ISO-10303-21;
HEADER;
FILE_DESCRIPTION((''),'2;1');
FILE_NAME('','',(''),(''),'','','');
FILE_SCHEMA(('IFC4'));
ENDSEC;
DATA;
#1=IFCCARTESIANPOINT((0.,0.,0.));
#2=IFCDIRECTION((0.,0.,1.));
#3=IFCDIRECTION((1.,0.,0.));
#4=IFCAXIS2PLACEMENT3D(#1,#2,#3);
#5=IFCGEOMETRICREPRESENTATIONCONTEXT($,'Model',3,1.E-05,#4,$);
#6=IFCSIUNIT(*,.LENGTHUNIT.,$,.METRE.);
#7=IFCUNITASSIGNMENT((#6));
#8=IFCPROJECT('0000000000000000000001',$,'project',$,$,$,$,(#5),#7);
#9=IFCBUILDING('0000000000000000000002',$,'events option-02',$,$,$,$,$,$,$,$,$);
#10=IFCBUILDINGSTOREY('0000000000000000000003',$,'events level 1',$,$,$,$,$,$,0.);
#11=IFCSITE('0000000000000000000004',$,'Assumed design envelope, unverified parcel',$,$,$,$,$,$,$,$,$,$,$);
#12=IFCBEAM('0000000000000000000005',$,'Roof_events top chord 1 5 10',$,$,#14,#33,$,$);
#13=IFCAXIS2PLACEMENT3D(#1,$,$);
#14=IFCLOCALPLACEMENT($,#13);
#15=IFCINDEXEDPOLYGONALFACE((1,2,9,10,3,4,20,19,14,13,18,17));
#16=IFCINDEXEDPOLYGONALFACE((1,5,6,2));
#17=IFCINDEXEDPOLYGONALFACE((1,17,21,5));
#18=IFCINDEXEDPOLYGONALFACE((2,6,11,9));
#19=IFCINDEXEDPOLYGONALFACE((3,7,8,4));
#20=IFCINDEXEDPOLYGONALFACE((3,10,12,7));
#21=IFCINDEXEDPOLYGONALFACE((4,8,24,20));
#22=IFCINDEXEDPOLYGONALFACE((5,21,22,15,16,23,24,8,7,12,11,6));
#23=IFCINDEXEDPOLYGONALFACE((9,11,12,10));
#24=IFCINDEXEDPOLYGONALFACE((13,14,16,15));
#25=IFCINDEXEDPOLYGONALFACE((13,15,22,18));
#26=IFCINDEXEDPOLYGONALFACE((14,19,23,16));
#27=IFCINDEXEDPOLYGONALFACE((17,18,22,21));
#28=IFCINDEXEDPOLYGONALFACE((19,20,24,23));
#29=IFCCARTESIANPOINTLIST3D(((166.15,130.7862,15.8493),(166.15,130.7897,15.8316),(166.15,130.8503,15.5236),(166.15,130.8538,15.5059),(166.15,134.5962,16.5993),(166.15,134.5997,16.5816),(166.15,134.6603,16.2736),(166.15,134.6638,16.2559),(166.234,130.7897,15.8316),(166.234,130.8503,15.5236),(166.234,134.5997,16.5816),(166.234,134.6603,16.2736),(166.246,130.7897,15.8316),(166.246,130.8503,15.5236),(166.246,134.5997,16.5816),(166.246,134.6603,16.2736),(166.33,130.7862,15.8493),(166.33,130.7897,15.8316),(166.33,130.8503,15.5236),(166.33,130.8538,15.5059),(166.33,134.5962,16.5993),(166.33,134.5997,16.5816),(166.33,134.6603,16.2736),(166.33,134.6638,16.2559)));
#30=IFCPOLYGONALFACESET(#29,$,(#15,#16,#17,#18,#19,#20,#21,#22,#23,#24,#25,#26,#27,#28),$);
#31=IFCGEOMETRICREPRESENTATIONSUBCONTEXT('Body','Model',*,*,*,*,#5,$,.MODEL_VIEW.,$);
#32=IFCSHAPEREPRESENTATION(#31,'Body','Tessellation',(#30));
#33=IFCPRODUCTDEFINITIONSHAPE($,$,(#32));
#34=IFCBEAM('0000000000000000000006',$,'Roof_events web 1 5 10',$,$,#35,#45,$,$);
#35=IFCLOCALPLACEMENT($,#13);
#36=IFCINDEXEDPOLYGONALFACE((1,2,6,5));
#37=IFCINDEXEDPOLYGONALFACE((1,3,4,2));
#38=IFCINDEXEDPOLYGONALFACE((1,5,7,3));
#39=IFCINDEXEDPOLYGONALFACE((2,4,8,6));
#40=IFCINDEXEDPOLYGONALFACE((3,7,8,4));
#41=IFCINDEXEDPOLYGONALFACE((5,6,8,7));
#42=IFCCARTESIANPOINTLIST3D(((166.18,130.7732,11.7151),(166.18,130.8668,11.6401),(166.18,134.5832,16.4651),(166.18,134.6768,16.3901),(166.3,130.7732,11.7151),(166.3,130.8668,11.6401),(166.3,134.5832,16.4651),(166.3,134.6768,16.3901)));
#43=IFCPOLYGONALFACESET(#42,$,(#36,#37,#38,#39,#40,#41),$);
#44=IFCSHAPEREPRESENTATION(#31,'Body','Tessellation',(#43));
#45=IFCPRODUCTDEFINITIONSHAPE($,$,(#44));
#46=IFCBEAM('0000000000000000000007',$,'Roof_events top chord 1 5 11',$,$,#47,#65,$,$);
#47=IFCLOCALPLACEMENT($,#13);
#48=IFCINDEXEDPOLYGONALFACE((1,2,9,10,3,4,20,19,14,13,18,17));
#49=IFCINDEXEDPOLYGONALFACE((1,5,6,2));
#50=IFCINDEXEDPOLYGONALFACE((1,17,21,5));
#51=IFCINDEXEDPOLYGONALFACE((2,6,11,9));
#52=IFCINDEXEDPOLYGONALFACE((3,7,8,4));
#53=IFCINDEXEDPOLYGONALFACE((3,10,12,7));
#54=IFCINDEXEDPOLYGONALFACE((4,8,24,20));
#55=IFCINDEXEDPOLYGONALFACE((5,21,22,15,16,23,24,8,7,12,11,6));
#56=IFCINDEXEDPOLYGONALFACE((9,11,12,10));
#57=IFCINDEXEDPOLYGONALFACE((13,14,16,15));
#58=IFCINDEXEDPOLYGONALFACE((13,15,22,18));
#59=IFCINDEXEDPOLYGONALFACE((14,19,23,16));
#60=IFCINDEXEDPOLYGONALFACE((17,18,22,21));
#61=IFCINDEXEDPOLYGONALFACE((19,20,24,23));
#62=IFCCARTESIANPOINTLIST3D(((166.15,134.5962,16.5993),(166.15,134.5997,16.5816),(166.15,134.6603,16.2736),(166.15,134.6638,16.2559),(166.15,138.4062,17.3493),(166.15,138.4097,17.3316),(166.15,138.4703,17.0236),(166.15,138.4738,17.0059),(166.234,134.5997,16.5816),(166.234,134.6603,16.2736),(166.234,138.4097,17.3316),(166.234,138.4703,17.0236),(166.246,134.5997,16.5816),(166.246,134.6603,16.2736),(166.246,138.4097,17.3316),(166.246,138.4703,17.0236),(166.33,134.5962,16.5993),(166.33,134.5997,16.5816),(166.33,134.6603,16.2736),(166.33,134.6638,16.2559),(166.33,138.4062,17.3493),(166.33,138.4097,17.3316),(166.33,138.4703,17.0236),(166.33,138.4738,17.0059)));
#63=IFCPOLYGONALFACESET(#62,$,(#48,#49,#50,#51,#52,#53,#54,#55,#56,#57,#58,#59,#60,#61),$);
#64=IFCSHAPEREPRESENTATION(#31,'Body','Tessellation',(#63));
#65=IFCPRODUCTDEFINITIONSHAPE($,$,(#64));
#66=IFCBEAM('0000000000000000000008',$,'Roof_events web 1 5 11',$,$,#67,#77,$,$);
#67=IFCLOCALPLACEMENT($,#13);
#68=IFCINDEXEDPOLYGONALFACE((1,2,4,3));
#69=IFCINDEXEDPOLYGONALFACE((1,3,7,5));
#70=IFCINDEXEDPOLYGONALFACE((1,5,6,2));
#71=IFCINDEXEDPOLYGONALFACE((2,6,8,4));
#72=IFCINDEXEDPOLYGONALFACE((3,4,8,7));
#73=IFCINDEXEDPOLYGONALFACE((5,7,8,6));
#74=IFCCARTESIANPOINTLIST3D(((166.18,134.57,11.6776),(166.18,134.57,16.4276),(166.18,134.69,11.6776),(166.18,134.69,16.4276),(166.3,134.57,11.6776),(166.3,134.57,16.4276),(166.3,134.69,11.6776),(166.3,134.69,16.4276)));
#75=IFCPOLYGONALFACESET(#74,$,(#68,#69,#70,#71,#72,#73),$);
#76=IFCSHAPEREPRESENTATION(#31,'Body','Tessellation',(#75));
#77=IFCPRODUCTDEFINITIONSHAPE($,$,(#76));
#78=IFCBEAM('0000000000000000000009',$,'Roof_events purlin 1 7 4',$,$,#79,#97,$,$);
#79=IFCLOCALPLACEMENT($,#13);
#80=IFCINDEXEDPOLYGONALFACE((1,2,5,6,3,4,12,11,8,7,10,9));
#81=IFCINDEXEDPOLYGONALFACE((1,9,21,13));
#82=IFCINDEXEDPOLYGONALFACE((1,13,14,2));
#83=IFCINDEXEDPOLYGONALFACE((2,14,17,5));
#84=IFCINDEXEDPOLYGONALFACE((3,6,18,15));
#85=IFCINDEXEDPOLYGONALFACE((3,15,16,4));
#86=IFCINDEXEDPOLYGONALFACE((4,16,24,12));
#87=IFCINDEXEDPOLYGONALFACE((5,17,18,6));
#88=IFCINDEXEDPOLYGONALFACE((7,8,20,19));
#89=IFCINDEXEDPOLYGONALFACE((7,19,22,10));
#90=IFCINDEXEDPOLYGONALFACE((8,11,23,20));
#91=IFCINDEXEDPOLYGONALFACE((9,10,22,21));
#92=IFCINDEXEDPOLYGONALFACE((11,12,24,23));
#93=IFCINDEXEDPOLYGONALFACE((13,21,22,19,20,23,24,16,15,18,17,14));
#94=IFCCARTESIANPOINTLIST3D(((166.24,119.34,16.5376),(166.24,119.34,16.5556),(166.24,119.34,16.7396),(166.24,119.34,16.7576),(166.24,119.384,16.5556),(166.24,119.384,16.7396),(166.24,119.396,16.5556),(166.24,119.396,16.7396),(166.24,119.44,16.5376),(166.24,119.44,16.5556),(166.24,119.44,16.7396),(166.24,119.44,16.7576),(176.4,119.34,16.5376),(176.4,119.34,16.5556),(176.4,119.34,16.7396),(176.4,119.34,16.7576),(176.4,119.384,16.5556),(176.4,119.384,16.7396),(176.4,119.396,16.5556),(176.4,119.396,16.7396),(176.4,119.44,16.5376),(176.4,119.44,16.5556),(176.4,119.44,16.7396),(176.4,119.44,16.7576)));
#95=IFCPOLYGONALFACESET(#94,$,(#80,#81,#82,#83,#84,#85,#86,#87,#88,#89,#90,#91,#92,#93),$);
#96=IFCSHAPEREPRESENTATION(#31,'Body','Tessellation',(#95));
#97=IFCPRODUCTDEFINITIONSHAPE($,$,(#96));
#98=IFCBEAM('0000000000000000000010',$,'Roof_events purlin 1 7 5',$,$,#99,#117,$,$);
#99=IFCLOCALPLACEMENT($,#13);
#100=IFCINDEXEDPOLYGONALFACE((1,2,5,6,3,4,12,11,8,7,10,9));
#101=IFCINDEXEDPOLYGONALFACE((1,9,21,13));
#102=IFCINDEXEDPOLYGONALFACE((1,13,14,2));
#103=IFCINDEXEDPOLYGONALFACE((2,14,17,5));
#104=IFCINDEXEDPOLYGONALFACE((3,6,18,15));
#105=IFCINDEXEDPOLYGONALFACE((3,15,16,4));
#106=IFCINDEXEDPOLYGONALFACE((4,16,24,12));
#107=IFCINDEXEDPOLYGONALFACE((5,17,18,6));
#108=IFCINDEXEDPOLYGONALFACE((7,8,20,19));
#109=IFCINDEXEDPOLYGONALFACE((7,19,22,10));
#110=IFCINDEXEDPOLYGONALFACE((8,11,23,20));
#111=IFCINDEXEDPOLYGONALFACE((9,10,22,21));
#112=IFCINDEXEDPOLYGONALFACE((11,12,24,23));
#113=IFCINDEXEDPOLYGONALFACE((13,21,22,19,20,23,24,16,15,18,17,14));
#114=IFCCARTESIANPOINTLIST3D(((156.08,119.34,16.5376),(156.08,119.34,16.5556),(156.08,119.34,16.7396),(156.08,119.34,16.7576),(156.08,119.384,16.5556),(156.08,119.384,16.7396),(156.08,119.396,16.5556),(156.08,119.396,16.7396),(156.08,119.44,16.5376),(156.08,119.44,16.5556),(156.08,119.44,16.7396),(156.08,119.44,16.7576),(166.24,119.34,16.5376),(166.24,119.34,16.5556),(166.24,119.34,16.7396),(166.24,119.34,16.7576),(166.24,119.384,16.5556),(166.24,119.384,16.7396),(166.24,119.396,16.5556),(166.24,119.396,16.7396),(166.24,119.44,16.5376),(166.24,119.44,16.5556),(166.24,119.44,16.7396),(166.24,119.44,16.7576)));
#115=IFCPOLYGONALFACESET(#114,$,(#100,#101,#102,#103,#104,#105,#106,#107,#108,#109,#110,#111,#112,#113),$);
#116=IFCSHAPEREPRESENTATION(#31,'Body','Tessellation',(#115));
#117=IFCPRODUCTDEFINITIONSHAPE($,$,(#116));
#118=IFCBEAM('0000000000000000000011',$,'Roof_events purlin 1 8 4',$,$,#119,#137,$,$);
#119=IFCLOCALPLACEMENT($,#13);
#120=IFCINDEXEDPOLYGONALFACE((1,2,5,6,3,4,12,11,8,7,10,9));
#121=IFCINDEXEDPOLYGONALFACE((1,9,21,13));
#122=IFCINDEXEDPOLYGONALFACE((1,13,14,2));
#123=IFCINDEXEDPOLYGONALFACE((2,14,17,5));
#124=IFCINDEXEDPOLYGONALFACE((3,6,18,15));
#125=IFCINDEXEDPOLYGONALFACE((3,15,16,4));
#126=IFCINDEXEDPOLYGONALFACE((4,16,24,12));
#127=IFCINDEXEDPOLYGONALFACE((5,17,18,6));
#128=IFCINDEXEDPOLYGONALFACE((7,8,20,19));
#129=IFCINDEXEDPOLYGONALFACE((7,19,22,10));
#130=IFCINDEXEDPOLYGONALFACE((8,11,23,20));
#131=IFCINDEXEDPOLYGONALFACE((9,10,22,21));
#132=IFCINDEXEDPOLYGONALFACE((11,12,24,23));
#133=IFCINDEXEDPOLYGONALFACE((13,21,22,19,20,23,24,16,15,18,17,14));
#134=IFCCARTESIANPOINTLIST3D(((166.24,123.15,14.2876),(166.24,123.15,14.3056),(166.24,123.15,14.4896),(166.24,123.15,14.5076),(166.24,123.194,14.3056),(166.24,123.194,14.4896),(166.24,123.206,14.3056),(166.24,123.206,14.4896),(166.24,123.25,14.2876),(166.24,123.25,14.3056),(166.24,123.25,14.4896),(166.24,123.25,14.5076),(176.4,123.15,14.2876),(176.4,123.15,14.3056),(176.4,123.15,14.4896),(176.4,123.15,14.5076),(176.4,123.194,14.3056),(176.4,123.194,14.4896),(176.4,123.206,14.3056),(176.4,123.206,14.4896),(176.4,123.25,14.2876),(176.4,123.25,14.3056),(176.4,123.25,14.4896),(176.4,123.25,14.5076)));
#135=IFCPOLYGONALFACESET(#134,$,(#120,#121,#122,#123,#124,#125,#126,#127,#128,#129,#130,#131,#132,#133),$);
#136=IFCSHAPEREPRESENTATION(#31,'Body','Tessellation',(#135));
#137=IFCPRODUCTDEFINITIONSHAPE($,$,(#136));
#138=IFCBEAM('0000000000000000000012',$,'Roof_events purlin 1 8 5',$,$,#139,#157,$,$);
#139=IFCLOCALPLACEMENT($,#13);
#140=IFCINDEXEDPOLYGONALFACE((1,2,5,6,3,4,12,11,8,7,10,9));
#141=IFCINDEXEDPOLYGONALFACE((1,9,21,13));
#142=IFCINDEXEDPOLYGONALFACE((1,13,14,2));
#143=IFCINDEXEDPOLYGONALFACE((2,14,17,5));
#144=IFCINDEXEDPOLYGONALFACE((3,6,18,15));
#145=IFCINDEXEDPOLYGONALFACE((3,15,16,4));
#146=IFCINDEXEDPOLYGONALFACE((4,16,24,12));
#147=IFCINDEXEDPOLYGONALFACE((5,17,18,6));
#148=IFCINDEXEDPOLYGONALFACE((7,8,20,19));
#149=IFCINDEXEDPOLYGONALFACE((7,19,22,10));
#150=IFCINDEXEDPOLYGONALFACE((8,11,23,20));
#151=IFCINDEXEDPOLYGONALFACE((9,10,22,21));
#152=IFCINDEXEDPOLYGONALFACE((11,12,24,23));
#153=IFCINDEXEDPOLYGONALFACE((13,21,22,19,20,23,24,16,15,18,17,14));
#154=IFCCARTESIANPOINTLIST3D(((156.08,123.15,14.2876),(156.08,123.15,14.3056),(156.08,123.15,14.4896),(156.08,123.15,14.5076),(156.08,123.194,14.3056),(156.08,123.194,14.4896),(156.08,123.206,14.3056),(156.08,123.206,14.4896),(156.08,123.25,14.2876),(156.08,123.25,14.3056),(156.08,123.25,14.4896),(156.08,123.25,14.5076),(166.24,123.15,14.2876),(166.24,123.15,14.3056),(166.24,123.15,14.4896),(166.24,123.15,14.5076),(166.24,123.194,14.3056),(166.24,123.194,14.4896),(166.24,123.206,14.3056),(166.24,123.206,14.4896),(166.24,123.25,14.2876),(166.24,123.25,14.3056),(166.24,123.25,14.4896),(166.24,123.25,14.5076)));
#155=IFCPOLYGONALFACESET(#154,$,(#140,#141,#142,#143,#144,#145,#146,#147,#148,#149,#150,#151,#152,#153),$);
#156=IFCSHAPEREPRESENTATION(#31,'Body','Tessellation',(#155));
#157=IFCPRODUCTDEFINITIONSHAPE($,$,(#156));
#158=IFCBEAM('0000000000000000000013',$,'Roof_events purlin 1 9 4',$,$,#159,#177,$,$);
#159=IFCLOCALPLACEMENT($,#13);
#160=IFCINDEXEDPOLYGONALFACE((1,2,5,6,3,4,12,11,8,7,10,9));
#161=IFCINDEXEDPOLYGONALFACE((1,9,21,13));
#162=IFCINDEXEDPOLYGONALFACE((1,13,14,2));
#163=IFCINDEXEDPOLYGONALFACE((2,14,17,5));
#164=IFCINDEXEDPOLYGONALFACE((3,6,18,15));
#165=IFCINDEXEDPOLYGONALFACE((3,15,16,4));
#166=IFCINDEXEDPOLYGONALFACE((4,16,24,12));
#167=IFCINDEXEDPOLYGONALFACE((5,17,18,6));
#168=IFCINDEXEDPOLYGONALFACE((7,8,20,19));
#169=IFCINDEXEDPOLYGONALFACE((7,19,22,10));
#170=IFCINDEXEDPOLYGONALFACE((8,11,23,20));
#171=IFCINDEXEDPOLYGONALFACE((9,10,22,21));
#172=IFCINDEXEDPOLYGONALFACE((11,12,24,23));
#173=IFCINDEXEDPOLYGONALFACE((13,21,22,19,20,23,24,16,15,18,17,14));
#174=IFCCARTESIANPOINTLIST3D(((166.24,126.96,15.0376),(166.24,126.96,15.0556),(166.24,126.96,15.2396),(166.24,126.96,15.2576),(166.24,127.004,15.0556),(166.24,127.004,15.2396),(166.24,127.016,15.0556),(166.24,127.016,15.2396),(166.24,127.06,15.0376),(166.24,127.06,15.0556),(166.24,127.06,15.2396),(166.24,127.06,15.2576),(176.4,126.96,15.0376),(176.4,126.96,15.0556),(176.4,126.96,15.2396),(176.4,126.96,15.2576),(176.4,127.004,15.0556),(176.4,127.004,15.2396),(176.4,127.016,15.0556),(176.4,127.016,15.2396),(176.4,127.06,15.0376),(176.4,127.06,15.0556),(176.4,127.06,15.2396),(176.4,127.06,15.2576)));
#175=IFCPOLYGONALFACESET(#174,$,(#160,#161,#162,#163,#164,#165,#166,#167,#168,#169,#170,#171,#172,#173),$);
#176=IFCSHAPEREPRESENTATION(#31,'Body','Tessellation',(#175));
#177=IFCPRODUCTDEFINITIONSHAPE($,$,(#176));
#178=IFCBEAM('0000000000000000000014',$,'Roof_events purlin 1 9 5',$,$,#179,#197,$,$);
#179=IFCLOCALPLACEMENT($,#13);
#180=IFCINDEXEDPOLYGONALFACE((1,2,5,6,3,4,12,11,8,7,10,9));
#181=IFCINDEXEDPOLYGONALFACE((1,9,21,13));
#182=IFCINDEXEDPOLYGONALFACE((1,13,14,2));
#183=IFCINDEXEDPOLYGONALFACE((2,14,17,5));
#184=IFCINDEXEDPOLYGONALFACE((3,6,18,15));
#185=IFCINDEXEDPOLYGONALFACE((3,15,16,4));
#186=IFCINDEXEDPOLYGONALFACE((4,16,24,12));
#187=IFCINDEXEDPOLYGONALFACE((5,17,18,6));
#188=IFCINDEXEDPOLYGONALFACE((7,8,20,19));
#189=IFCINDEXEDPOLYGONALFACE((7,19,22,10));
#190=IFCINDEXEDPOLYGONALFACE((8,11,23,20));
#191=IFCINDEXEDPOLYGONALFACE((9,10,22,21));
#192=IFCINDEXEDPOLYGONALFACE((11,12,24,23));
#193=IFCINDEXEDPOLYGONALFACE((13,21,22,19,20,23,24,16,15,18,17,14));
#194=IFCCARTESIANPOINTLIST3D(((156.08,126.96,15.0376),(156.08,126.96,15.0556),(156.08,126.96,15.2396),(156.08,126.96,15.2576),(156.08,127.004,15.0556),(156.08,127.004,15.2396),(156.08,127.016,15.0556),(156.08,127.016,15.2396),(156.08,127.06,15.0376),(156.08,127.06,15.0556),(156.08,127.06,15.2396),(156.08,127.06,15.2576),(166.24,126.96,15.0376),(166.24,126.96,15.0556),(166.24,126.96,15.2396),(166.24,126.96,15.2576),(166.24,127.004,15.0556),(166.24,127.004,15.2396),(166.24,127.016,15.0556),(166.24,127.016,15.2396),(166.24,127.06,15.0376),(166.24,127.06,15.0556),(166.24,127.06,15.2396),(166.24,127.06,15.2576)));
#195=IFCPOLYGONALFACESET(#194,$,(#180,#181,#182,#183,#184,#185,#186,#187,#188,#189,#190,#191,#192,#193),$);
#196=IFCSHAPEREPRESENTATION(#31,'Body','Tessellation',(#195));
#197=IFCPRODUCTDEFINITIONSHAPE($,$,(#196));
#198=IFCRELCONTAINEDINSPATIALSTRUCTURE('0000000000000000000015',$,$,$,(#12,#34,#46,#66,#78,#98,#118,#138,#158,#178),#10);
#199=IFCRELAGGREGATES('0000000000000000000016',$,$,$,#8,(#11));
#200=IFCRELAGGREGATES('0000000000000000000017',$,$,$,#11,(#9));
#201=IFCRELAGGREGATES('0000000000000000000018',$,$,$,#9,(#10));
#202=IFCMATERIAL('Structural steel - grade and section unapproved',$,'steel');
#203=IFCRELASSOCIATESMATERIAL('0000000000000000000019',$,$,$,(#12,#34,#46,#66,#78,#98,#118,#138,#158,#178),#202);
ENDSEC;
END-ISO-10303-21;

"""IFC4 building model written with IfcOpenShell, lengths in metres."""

from ifc_helpers import new_model, si_unit, frame, origin_with_axes, place, context, subcontext, project, spatial, rectangle, i_section, extrude, material, element, save


model = new_model("IFC4")

# Units and contexts
model_context = context("Model", 3, precision=1e-05, world=origin_with_axes())
body_context = subcontext(model_context, "Body", "Model", "MODEL_VIEW")
ifc_project = project(units=[si_unit("LENGTHUNIT", "METRE")], contexts=[model_context])

# Site, building, storey
site = spatial("IfcSite", under=ifc_project, Name="Assumed design envelope, unverified parcel")
building = spatial("IfcBuilding", under=site, Name="events option-02")
storey = spatial("IfcBuildingStorey", under=building, Name="events level 1", Elevation=0.0)

# Beams
ifc_material_1 = material(Name="Structural steel - grade and section unapproved", Category="steel")
beam_1_placement = place(None, frame((166.24, 130.82, 15.6776), z_axis=(0.0, 0.98117, 0.193144), x_axis=(-1.0, 0.0, 0.0)))
element("IfcBeam", 1, at=beam_1_placement, inside=storey, material=ifc_material_1, Name="Roof_events top chord 1 5 10", context=body_context, shape_type="SweptSolid", body=[
    extrude(i_section(OverallWidth=0.18, OverallDepth=0.35, WebThickness=0.012, FlangeThickness=0.018, FilletRadius=0.0), origin_with_axes(), (0.0, 0.0, 1.0), 3.8831),
])
beam_2_placement = place(None, frame((166.24, 130.82, 11.6776), z_axis=(0.0, 0.625696, 0.780067), x_axis=(-1.0, 0.0, 0.0)))
element("IfcBeam", 2, at=beam_2_placement, inside=storey, material=ifc_material_1, Name="Roof_events web 1 5 10", context=body_context, shape_type="SweptSolid", body=[
    extrude(rectangle(XDim=0.12, YDim=0.12), origin_with_axes(), (0.0, 0.0, 1.0), 6.0892),
])
beam_3_placement = place(None, frame((166.24, 134.63, 16.4276), z_axis=(0.0, 0.98117, 0.193144), x_axis=(-1.0, 0.0, 0.0)))
element("IfcBeam", 3, at=beam_3_placement, inside=storey, material=ifc_material_1, Name="Roof_events top chord 1 5 11", context=body_context, shape_type="SweptSolid", body=[
    extrude(i_section(OverallWidth=0.18, OverallDepth=0.35, WebThickness=0.012, FlangeThickness=0.018, FilletRadius=0.0), origin_with_axes(), (0.0, 0.0, 1.0), 3.8831),
])
beam_4_placement = place(None, frame((166.24, 134.63, 11.6776), z_axis=(0.0, 0.0, 1.0), x_axis=(-1.0, 0.0, 0.0)))
element("IfcBeam", 4, at=beam_4_placement, inside=storey, material=ifc_material_1, Name="Roof_events web 1 5 11", context=body_context, shape_type="SweptSolid", body=[
    extrude(rectangle(XDim=0.12, YDim=0.12), origin_with_axes(), (0.0, 0.0, 1.0), 4.75),
])
beam_5_placement = place(None, frame((176.4, 119.39, 16.6476), z_axis=(-1.0, 0.0, 0.0), x_axis=(0.0, -1.0, 0.0)))
element("IfcBeam", 5, at=beam_5_placement, inside=storey, material=ifc_material_1, Name="Roof_events purlin 1 7 4", context=body_context, shape_type="SweptSolid", body=[
    extrude(i_section(OverallWidth=0.1, OverallDepth=0.22, WebThickness=0.012, FlangeThickness=0.018, FilletRadius=0.0), origin_with_axes(), (0.0, 0.0, 1.0), 10.16),
])
beam_6_placement = place(None, frame((166.24, 119.39, 16.6476), z_axis=(-1.0, 0.0, 0.0), x_axis=(0.0, -1.0, 0.0)))
element("IfcBeam", 6, at=beam_6_placement, inside=storey, material=ifc_material_1, Name="Roof_events purlin 1 7 5", context=body_context, shape_type="SweptSolid", body=[
    extrude(i_section(OverallWidth=0.1, OverallDepth=0.22, WebThickness=0.012, FlangeThickness=0.018, FilletRadius=0.0), origin_with_axes(), (0.0, 0.0, 1.0), 10.16),
])
beam_7_placement = place(None, frame((176.4, 123.2, 14.3976), z_axis=(-1.0, 0.0, 0.0), x_axis=(0.0, -1.0, 0.0)))
element("IfcBeam", 7, at=beam_7_placement, inside=storey, material=ifc_material_1, Name="Roof_events purlin 1 8 4", context=body_context, shape_type="SweptSolid", body=[
    extrude(i_section(OverallWidth=0.1, OverallDepth=0.22, WebThickness=0.012, FlangeThickness=0.018, FilletRadius=0.0), origin_with_axes(), (0.0, 0.0, 1.0), 10.16),
])
beam_8_placement = place(None, frame((166.24, 123.2, 14.3976), z_axis=(-1.0, 0.0, 0.0), x_axis=(0.0, -1.0, 0.0)))
element("IfcBeam", 8, at=beam_8_placement, inside=storey, material=ifc_material_1, Name="Roof_events purlin 1 8 5", context=body_context, shape_type="SweptSolid", body=[
    extrude(i_section(OverallWidth=0.1, OverallDepth=0.22, WebThickness=0.012, FlangeThickness=0.018, FilletRadius=0.0), origin_with_axes(), (0.0, 0.0, 1.0), 10.16),
])
beam_9_placement = place(None, frame((176.4, 127.01, 15.1476), z_axis=(-1.0, 0.0, 0.0), x_axis=(0.0, -1.0, 0.0)))
element("IfcBeam", 9, at=beam_9_placement, inside=storey, material=ifc_material_1, Name="Roof_events purlin 1 9 4", context=body_context, shape_type="SweptSolid", body=[
    extrude(i_section(OverallWidth=0.1, OverallDepth=0.22, WebThickness=0.012, FlangeThickness=0.018, FilletRadius=0.0), origin_with_axes(), (0.0, 0.0, 1.0), 10.16),
])
for number, where, z_axis, x_axis, name in (
    (10, (166.24, 127.01, 15.1476), (-1.0, 0.0, 0.0), (0.0, -1.0, 0.0), "Roof_events purlin 1 9 5"),
):
    element("IfcBeam", number, at=place(None, frame(where, z_axis=z_axis, x_axis=x_axis)), inside=storey, material=ifc_material_1, Name=name, context=body_context, shape_type="SweptSolid", body=[
        extrude(i_section(OverallWidth=0.1, OverallDepth=0.22, WebThickness=0.012, FlangeThickness=0.018, FilletRadius=0.0), origin_with_axes(), (0.0, 0.0, 1.0), 10.16),
    ])

save(model, "model.ifc")
